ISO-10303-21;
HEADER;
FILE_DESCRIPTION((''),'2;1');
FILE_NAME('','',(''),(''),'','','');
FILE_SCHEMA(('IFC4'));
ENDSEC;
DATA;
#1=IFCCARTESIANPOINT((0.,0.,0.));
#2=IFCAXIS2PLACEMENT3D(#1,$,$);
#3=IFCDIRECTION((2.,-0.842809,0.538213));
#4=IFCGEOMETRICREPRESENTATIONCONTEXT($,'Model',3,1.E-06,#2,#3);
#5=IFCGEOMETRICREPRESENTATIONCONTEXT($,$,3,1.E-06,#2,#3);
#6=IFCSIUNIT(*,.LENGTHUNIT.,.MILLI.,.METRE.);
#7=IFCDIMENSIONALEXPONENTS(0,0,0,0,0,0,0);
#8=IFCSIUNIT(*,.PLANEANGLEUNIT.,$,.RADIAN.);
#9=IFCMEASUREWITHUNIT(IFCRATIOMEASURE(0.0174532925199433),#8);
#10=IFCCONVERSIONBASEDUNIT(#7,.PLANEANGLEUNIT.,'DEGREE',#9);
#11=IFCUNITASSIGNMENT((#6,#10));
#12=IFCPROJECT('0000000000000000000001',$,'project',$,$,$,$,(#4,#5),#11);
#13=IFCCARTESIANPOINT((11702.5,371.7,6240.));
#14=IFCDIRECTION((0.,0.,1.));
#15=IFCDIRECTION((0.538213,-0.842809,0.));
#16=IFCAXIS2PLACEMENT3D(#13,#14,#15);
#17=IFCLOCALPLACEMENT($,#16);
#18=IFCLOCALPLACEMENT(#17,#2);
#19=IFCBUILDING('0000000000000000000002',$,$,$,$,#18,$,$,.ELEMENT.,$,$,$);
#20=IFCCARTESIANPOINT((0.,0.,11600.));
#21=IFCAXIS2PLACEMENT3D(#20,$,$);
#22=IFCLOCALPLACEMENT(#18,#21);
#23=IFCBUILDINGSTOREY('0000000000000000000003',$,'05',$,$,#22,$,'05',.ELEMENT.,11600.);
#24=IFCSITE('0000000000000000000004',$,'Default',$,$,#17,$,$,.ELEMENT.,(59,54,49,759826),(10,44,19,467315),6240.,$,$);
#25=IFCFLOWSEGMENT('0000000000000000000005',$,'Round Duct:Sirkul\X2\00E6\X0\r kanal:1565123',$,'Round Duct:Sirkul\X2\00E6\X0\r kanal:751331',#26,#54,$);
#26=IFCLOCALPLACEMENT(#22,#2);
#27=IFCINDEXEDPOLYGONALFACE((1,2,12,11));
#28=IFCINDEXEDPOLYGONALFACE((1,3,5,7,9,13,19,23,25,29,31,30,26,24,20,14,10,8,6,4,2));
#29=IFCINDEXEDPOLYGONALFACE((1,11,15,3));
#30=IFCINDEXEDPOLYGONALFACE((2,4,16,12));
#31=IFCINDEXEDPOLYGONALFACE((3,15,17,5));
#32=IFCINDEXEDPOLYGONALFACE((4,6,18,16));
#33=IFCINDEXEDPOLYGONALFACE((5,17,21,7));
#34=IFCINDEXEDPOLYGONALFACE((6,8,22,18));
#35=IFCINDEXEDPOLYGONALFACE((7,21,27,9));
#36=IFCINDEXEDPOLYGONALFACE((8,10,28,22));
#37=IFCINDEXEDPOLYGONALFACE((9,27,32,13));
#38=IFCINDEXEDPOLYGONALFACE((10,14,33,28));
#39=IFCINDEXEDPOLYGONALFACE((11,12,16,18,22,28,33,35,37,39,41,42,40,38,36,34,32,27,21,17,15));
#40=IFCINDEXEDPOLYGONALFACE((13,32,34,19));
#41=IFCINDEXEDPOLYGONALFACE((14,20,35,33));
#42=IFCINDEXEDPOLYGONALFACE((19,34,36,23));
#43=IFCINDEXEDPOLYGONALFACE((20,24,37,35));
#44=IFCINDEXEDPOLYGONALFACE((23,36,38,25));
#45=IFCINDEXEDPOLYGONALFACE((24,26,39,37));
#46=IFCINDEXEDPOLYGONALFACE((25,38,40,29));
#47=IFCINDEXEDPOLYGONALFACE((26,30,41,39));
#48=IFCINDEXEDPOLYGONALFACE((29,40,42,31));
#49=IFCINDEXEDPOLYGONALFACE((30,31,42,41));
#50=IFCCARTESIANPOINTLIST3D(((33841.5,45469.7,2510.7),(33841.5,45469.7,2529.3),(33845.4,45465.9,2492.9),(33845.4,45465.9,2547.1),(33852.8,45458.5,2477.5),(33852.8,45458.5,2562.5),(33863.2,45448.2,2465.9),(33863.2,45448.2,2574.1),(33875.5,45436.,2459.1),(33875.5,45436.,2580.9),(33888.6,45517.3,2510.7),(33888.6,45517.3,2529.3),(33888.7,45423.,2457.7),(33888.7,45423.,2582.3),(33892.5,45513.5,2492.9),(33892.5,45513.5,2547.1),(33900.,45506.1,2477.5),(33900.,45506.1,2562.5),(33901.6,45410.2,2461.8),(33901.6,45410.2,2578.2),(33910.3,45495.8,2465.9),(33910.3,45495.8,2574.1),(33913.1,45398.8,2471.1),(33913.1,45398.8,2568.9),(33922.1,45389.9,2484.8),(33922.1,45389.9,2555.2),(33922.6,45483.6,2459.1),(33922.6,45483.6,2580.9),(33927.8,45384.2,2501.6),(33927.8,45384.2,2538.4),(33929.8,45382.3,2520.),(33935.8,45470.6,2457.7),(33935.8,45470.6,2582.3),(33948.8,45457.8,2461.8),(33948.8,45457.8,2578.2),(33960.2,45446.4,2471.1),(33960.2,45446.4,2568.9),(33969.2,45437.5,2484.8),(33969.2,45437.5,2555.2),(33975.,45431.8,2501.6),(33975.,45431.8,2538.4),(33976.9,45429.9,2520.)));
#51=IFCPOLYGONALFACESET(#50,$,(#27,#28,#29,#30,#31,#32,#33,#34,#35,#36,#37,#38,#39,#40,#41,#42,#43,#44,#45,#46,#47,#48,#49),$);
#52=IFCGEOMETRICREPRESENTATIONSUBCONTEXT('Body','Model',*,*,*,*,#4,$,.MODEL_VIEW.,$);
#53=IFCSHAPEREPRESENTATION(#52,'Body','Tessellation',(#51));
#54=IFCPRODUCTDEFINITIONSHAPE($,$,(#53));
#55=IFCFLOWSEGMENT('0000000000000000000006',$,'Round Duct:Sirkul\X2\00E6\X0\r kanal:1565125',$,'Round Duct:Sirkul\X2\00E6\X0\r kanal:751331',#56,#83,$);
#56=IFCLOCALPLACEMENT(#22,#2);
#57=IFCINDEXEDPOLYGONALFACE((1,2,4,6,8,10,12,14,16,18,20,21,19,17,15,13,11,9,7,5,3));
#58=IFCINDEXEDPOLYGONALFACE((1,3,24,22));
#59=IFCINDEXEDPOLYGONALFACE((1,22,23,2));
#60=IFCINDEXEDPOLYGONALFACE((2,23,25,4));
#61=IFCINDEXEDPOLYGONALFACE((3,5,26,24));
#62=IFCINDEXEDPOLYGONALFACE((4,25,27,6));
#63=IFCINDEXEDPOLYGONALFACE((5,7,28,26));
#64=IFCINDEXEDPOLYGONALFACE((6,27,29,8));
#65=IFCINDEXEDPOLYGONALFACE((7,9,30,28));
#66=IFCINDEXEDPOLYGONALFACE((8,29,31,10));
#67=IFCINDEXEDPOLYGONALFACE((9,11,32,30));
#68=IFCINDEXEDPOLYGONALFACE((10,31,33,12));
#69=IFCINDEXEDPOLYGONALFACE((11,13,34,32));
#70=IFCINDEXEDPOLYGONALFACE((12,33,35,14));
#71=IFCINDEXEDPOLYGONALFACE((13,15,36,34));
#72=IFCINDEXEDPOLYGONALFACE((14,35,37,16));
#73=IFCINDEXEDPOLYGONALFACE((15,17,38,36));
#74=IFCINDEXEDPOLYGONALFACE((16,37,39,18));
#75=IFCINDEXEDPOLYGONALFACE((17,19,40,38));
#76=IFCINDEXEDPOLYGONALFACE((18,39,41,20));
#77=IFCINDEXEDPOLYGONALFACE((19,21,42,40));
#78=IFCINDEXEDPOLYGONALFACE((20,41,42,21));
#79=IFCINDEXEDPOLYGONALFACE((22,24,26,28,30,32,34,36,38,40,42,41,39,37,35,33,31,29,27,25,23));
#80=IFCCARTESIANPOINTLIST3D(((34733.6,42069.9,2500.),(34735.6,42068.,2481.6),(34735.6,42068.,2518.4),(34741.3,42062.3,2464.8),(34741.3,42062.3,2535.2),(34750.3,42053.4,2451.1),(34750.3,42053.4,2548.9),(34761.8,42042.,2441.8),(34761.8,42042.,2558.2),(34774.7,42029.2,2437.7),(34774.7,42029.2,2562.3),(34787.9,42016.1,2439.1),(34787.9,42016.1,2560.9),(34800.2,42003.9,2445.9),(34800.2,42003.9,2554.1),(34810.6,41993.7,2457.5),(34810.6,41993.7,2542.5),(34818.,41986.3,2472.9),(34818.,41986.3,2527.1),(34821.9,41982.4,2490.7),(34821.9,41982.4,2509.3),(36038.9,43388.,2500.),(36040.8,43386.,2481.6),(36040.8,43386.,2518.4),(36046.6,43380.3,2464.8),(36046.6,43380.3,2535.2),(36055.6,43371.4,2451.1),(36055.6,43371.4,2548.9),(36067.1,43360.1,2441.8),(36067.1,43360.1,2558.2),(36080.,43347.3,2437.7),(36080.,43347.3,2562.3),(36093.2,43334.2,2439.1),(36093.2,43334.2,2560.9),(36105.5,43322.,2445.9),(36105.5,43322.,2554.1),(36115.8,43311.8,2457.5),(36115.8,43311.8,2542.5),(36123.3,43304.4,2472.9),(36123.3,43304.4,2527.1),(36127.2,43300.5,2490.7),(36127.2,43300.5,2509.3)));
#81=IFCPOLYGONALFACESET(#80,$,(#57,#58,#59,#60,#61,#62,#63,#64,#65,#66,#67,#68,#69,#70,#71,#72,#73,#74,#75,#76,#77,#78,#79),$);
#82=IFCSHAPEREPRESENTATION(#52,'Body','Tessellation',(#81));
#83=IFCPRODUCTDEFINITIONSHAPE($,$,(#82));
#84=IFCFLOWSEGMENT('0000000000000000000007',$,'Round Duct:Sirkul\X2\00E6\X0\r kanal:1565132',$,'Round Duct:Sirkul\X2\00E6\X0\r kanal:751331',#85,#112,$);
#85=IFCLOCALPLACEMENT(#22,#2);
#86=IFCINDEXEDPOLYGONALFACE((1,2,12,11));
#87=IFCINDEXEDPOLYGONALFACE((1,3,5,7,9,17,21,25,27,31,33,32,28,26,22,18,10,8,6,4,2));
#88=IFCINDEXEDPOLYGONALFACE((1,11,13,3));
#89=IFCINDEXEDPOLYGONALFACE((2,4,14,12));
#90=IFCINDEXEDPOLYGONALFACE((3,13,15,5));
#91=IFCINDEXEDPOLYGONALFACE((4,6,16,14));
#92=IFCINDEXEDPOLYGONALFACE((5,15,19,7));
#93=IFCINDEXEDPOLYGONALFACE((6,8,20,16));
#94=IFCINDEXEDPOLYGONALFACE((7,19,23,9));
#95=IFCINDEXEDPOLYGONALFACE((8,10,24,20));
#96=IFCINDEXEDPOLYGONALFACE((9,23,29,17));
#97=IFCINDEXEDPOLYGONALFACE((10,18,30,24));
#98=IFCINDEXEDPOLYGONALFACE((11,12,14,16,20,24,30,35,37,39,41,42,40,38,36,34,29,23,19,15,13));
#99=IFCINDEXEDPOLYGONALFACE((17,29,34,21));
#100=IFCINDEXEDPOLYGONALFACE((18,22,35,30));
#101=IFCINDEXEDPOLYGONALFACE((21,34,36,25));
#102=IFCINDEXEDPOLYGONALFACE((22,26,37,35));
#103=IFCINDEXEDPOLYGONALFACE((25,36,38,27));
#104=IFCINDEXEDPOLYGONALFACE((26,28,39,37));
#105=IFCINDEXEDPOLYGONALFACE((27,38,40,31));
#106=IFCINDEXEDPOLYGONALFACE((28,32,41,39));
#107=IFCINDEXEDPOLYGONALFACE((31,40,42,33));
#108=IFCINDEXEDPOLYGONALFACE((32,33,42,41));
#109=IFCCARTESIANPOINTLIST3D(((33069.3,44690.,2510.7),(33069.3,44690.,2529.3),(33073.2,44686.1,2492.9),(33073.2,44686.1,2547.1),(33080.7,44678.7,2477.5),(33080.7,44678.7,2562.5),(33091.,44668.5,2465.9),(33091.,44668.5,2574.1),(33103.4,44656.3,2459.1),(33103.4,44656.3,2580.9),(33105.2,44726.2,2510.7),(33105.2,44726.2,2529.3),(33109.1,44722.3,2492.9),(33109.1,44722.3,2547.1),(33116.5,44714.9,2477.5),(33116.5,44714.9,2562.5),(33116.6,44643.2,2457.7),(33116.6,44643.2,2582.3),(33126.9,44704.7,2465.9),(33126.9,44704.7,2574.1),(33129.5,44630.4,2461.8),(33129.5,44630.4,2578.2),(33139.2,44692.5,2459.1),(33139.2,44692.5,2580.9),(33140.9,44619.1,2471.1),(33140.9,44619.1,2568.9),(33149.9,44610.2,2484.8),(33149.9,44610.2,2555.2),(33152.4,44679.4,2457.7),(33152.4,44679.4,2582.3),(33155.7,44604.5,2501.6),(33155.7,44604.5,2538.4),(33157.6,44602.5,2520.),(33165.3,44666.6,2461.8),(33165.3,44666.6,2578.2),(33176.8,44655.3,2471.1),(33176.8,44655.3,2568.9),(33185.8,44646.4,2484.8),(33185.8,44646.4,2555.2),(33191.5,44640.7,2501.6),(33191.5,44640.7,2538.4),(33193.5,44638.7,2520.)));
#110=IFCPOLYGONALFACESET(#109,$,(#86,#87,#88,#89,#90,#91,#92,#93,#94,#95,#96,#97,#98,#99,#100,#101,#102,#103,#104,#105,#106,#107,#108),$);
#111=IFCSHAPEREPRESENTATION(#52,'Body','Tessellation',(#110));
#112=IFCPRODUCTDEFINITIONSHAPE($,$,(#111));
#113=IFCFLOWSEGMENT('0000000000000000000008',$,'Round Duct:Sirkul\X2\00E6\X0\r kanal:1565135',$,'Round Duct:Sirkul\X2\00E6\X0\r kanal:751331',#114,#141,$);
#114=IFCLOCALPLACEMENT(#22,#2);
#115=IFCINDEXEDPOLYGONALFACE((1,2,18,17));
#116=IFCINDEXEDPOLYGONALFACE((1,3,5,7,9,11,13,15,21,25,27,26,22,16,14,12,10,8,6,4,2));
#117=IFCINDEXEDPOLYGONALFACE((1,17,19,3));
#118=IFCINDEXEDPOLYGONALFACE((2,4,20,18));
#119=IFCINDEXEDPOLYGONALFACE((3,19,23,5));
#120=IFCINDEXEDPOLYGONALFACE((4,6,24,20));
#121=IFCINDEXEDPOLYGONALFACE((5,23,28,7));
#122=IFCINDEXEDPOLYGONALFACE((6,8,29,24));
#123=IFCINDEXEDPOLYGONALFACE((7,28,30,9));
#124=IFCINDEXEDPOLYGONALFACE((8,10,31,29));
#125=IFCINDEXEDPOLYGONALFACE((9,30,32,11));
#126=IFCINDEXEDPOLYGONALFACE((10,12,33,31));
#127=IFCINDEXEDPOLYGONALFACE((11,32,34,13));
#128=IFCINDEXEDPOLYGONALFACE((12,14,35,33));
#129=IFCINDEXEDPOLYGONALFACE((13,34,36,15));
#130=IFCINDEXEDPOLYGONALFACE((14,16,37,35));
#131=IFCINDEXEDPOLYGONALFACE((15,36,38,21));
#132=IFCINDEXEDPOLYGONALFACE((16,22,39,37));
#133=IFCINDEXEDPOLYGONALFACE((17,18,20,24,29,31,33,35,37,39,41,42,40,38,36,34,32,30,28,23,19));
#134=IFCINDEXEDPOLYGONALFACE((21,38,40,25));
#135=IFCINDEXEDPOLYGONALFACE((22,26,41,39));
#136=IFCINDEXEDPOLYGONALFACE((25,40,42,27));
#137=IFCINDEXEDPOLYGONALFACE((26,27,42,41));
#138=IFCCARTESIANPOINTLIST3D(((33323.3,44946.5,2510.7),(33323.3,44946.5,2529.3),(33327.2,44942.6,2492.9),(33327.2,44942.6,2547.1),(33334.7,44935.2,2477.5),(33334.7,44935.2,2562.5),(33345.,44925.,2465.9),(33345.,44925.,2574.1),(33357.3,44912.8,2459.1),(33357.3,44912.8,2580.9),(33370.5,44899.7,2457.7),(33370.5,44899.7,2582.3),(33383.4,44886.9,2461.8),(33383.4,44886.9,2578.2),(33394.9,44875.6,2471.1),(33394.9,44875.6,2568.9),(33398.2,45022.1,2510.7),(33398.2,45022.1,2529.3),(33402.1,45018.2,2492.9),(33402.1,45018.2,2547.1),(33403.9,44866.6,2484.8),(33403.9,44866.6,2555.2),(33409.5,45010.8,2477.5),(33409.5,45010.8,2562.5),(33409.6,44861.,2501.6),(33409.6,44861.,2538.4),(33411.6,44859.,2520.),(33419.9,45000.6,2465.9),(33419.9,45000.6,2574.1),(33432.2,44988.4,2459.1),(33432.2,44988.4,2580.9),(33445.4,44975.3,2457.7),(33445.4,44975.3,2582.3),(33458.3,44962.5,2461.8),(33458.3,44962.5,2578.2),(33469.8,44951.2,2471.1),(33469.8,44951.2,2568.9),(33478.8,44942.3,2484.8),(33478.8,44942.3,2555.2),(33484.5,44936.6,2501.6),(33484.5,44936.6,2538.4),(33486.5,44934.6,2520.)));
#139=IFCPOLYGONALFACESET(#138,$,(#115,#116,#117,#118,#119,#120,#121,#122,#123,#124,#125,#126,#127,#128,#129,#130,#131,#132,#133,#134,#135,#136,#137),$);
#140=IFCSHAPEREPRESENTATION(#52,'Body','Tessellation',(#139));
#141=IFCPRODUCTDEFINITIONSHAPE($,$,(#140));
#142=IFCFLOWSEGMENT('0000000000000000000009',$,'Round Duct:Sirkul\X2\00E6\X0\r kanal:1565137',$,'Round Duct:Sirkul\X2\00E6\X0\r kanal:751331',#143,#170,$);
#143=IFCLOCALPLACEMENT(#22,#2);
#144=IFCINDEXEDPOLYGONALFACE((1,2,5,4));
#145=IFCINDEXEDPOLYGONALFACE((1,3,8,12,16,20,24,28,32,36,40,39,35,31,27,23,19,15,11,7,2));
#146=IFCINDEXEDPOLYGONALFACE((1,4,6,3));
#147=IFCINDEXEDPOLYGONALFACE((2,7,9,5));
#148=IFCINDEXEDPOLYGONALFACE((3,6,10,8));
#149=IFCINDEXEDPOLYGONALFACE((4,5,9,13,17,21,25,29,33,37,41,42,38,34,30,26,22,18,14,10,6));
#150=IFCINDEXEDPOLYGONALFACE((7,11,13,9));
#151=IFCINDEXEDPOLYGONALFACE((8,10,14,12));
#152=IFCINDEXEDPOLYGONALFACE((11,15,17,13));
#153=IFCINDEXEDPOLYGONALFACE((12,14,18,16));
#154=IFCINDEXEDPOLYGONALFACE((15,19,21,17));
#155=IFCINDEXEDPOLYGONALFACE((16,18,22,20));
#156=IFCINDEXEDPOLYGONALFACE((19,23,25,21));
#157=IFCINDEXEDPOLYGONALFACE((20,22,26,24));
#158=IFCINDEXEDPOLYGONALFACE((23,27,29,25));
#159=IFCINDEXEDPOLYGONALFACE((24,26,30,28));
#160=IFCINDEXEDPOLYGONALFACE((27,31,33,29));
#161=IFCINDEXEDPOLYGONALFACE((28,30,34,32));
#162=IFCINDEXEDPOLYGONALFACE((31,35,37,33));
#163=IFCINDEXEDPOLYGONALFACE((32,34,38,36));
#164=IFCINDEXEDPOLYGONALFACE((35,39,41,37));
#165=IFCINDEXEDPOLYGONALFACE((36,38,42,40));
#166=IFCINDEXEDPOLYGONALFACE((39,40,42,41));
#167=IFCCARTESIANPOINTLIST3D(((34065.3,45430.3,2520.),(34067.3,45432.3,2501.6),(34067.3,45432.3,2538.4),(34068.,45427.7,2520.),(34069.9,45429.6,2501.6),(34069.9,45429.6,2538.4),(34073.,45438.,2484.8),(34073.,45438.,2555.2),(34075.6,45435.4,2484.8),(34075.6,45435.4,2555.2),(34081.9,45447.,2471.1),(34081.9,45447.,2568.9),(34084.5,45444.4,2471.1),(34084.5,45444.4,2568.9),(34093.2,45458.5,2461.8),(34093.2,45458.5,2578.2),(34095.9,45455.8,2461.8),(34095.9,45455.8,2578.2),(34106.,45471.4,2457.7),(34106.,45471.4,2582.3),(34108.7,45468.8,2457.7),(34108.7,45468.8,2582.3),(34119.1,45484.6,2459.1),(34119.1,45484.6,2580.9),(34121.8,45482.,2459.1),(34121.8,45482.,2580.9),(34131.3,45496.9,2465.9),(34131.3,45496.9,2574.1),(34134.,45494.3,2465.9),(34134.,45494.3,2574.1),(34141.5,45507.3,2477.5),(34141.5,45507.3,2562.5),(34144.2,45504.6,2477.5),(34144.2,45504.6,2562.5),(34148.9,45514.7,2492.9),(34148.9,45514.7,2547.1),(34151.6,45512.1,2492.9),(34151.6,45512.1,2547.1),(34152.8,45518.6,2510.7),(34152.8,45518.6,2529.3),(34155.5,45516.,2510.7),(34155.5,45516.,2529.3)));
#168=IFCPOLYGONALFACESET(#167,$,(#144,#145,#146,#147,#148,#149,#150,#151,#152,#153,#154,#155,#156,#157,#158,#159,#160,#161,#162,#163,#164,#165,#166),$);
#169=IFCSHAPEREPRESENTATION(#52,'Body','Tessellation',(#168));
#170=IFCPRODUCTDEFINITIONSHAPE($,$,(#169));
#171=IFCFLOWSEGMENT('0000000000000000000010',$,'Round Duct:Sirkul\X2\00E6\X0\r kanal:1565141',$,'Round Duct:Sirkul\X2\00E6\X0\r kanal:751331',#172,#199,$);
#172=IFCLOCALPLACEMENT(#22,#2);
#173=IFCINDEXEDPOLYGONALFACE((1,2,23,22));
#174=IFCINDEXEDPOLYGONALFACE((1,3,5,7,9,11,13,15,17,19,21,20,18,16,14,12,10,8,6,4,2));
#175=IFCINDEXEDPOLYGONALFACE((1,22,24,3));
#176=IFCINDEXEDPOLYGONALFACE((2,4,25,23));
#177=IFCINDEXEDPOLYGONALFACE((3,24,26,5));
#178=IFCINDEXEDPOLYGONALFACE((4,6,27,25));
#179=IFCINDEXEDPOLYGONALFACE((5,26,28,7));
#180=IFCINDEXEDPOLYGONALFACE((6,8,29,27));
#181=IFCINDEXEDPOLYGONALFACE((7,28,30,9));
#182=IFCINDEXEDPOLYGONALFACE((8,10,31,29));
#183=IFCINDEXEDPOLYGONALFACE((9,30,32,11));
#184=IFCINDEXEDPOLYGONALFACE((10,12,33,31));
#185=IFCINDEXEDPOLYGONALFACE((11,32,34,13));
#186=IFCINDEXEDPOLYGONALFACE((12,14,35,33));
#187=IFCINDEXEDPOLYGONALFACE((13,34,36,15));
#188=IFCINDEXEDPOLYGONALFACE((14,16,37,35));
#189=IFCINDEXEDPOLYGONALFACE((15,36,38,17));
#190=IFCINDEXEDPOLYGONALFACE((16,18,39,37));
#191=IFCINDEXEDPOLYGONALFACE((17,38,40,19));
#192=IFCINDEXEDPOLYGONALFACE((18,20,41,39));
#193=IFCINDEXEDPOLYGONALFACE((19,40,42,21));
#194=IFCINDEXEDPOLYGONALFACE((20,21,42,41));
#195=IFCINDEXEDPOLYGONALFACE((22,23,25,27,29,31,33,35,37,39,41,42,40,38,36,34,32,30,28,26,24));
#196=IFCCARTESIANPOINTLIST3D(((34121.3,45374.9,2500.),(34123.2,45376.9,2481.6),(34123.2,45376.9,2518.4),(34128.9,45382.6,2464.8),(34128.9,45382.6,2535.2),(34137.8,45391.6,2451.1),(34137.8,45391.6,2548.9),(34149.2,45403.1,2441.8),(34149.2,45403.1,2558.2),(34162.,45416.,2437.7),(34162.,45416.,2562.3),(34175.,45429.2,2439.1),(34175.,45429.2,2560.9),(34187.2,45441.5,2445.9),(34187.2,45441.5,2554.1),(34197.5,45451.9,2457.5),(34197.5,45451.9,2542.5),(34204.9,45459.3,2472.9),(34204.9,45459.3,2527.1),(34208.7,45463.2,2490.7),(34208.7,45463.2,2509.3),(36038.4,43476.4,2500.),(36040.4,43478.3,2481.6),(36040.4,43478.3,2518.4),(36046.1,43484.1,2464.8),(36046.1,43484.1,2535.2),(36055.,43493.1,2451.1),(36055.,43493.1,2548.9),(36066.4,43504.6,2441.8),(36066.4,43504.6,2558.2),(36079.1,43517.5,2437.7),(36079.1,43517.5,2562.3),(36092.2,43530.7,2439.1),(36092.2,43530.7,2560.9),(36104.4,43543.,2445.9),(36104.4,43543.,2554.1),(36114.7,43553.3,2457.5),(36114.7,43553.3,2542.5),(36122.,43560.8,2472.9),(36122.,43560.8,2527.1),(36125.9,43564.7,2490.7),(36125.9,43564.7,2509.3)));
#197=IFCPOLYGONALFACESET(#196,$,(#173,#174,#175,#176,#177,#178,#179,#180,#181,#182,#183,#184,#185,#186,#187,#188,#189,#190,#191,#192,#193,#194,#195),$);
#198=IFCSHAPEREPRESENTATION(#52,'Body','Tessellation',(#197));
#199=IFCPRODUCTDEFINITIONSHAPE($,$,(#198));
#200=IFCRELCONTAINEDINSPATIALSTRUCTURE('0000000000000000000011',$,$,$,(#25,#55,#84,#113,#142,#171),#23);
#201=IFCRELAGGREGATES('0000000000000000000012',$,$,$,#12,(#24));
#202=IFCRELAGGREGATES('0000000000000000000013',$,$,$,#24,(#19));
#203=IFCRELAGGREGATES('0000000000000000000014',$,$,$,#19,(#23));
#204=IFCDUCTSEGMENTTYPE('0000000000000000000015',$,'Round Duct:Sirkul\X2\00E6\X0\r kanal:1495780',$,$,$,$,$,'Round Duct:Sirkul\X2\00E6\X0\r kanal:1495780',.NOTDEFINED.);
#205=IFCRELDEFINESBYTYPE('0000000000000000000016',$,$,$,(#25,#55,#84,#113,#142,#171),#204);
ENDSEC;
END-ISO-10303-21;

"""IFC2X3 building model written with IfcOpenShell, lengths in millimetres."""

from ifc_helpers import new_model, entity, si_unit, converted_unit, direction, frame, frame_2d, origin, origin_2d_with_axis, place, context, subcontext, project, spatial, circle, extrude, type_object, element, save


model = new_model("IFC2X3")

# Units and contexts
model_context = context("Model", 3, precision=1e-06, world=origin(), true_north=direction((2.0, -0.842809, 0.538213)))
context_of_model = context(None, 3, precision=1e-06, world=origin(), true_north=direction((2.0, -0.842809, 0.538213)))
body_context = subcontext(model_context, "Body", "Model", "MODEL_VIEW")
ifc_project = project(units=[si_unit("LENGTHUNIT", "METRE", prefix="MILLI"), converted_unit("PLANEANGLEUNIT", "DEGREE", entity("IfcRatioMeasure", 0.0174532925199433), si_unit("PLANEANGLEUNIT", "RADIAN"), dimensions=[0, 0, 0, 0, 0, 0, 0])], contexts=[model_context, context_of_model])

# Site, building, storey
site_placement = place(None, frame((11702.5, 371.7, 6240.0), z_axis=(0.0, 0.0, 1.0), x_axis=(0.538213, -0.842809, 0.0)))
site = spatial("IfcSite", under=ifc_project, at=site_placement, Name="Default", CompositionType="ELEMENT", RefLatitude=(59, 54, 49, 759826), RefLongitude=(10, 44, 19, 467315), RefElevation=6240.0)
building_placement = place(site_placement, origin())
building = spatial("IfcBuilding", under=site, at=building_placement, CompositionType="ELEMENT")
storey_placement = place(building_placement, frame((0.0, 0.0, 11600.0)))
storey = spatial("IfcBuildingStorey", under=building, at=storey_placement, Name="05", LongName="05", CompositionType="ELEMENT", Elevation=11600.0)

# Flow segments
duct_segment_type = type_object("IfcDuctSegmentType", Name="Round Duct:Sirkulær kanal:1495780", ElementType="Round Duct:Sirkulær kanal:1495780", PredefinedType="NOTDEFINED")
flow_segment_1_placement = place(storey_placement, origin())
element("IfcFlowSegment", 1, at=flow_segment_1_placement, inside=storey, type_object=duct_segment_type, Name="Round Duct:Sirkulær kanal:1565123", ObjectType="Round Duct:Sirkulær kanal:751331", context=body_context, shape_type="SweptSolid", body=[
    extrude(circle(Radius=62.5, at=frame_2d((0.0, 0.0), x_axis=(1.0, 0.0))), frame((33885.4, 45426.2, 2520.0), z_axis=(0.703643, 0.710554, 0.0), x_axis=(0.710554, -0.703643, 0.0)), (0.0, 0.0, 1.0), 67.0),
])
flow_segment_2_placement = place(storey_placement, origin())
element("IfcFlowSegment", 2, at=flow_segment_2_placement, inside=storey, type_object=duct_segment_type, Name="Round Duct:Sirkulær kanal:1565125", ObjectType="Round Duct:Sirkulær kanal:751331", context=body_context, shape_type="SweptSolid", body=[
    extrude(circle(Radius=62.5, at=origin_2d_with_axis()), frame((34778.0, 42025.9, 2500.0), z_axis=(0.703643, 0.710554, 0.0), x_axis=(-0.710554, 0.703643, 0.0)), (0.0, 0.0, 1.0), 1855.0),
])
flow_segment_3_placement = place(storey_placement, origin())
element("IfcFlowSegment", 3, at=flow_segment_3_placement, inside=storey, type_object=duct_segment_type, Name="Round Duct:Sirkulær kanal:1565132", ObjectType="Round Duct:Sirkulær kanal:751331", context=body_context, shape_type="SweptSolid", body=[
    extrude(circle(Radius=62.5, at=frame_2d((0.0, 0.0), x_axis=(1.0, 0.0))), frame((33113.2, 44646.5, 2520.0), z_axis=(0.703643, 0.710554, 0.0), x_axis=(0.710554, -0.703643, 0.0)), (0.0, 0.0, 1.0), 50.9),
])
flow_segment_4_placement = place(storey_placement, origin())
element("IfcFlowSegment", 4, at=flow_segment_4_placement, inside=storey, type_object=duct_segment_type, Name="Round Duct:Sirkulær kanal:1565135", ObjectType="Round Duct:Sirkulær kanal:751331", context=body_context, shape_type="SweptSolid", body=[
    extrude(circle(Radius=62.5, at=frame_2d((0.0, 0.0), x_axis=(1.0, 0.0))), frame((33367.2, 44903.0, 2520.0), z_axis=(0.703643, 0.710554, 0.0), x_axis=(0.710554, -0.703643, 0.0)), (0.0, 0.0, 1.0), 106.4),
])
flow_segment_5_placement = place(storey_placement, origin())
element("IfcFlowSegment", 5, at=flow_segment_5_placement, inside=storey, type_object=duct_segment_type, Name="Round Duct:Sirkulær kanal:1565137", ObjectType="Round Duct:Sirkulær kanal:751331", context=body_context, shape_type="SweptSolid", body=[
    extrude(circle(Radius=62.5, at=frame_2d((0.0, 0.0), x_axis=(1.0, 0.0))), frame((34109.3, 45474.7, 2520.0), z_axis=(0.710554, -0.703643, 0.0), x_axis=(-0.703643, -0.710554, 0.0)), (0.0, 0.0, 1.0), 3.7),
])
flow_segment_6_placement = place(storey_placement, origin())
element("IfcFlowSegment", 6, at=flow_segment_6_placement, inside=storey, type_object=duct_segment_type, Name="Round Duct:Sirkulær kanal:1565141", ObjectType="Round Duct:Sirkulær kanal:751331", context=body_context, shape_type="SweptSolid", body=[
    extrude(circle(Radius=62.5, at=frame_2d((0.0, 0.0), x_axis=(1.0, 0.0))), frame((36082.4, 43520.8, 2500.0), z_axis=(-0.710554, 0.703643, 0.0), x_axis=(-0.703643, -0.710554, 0.0)), (0.0, 0.0, 1.0), 2698.1),
])

save(model, "model.ifc")
